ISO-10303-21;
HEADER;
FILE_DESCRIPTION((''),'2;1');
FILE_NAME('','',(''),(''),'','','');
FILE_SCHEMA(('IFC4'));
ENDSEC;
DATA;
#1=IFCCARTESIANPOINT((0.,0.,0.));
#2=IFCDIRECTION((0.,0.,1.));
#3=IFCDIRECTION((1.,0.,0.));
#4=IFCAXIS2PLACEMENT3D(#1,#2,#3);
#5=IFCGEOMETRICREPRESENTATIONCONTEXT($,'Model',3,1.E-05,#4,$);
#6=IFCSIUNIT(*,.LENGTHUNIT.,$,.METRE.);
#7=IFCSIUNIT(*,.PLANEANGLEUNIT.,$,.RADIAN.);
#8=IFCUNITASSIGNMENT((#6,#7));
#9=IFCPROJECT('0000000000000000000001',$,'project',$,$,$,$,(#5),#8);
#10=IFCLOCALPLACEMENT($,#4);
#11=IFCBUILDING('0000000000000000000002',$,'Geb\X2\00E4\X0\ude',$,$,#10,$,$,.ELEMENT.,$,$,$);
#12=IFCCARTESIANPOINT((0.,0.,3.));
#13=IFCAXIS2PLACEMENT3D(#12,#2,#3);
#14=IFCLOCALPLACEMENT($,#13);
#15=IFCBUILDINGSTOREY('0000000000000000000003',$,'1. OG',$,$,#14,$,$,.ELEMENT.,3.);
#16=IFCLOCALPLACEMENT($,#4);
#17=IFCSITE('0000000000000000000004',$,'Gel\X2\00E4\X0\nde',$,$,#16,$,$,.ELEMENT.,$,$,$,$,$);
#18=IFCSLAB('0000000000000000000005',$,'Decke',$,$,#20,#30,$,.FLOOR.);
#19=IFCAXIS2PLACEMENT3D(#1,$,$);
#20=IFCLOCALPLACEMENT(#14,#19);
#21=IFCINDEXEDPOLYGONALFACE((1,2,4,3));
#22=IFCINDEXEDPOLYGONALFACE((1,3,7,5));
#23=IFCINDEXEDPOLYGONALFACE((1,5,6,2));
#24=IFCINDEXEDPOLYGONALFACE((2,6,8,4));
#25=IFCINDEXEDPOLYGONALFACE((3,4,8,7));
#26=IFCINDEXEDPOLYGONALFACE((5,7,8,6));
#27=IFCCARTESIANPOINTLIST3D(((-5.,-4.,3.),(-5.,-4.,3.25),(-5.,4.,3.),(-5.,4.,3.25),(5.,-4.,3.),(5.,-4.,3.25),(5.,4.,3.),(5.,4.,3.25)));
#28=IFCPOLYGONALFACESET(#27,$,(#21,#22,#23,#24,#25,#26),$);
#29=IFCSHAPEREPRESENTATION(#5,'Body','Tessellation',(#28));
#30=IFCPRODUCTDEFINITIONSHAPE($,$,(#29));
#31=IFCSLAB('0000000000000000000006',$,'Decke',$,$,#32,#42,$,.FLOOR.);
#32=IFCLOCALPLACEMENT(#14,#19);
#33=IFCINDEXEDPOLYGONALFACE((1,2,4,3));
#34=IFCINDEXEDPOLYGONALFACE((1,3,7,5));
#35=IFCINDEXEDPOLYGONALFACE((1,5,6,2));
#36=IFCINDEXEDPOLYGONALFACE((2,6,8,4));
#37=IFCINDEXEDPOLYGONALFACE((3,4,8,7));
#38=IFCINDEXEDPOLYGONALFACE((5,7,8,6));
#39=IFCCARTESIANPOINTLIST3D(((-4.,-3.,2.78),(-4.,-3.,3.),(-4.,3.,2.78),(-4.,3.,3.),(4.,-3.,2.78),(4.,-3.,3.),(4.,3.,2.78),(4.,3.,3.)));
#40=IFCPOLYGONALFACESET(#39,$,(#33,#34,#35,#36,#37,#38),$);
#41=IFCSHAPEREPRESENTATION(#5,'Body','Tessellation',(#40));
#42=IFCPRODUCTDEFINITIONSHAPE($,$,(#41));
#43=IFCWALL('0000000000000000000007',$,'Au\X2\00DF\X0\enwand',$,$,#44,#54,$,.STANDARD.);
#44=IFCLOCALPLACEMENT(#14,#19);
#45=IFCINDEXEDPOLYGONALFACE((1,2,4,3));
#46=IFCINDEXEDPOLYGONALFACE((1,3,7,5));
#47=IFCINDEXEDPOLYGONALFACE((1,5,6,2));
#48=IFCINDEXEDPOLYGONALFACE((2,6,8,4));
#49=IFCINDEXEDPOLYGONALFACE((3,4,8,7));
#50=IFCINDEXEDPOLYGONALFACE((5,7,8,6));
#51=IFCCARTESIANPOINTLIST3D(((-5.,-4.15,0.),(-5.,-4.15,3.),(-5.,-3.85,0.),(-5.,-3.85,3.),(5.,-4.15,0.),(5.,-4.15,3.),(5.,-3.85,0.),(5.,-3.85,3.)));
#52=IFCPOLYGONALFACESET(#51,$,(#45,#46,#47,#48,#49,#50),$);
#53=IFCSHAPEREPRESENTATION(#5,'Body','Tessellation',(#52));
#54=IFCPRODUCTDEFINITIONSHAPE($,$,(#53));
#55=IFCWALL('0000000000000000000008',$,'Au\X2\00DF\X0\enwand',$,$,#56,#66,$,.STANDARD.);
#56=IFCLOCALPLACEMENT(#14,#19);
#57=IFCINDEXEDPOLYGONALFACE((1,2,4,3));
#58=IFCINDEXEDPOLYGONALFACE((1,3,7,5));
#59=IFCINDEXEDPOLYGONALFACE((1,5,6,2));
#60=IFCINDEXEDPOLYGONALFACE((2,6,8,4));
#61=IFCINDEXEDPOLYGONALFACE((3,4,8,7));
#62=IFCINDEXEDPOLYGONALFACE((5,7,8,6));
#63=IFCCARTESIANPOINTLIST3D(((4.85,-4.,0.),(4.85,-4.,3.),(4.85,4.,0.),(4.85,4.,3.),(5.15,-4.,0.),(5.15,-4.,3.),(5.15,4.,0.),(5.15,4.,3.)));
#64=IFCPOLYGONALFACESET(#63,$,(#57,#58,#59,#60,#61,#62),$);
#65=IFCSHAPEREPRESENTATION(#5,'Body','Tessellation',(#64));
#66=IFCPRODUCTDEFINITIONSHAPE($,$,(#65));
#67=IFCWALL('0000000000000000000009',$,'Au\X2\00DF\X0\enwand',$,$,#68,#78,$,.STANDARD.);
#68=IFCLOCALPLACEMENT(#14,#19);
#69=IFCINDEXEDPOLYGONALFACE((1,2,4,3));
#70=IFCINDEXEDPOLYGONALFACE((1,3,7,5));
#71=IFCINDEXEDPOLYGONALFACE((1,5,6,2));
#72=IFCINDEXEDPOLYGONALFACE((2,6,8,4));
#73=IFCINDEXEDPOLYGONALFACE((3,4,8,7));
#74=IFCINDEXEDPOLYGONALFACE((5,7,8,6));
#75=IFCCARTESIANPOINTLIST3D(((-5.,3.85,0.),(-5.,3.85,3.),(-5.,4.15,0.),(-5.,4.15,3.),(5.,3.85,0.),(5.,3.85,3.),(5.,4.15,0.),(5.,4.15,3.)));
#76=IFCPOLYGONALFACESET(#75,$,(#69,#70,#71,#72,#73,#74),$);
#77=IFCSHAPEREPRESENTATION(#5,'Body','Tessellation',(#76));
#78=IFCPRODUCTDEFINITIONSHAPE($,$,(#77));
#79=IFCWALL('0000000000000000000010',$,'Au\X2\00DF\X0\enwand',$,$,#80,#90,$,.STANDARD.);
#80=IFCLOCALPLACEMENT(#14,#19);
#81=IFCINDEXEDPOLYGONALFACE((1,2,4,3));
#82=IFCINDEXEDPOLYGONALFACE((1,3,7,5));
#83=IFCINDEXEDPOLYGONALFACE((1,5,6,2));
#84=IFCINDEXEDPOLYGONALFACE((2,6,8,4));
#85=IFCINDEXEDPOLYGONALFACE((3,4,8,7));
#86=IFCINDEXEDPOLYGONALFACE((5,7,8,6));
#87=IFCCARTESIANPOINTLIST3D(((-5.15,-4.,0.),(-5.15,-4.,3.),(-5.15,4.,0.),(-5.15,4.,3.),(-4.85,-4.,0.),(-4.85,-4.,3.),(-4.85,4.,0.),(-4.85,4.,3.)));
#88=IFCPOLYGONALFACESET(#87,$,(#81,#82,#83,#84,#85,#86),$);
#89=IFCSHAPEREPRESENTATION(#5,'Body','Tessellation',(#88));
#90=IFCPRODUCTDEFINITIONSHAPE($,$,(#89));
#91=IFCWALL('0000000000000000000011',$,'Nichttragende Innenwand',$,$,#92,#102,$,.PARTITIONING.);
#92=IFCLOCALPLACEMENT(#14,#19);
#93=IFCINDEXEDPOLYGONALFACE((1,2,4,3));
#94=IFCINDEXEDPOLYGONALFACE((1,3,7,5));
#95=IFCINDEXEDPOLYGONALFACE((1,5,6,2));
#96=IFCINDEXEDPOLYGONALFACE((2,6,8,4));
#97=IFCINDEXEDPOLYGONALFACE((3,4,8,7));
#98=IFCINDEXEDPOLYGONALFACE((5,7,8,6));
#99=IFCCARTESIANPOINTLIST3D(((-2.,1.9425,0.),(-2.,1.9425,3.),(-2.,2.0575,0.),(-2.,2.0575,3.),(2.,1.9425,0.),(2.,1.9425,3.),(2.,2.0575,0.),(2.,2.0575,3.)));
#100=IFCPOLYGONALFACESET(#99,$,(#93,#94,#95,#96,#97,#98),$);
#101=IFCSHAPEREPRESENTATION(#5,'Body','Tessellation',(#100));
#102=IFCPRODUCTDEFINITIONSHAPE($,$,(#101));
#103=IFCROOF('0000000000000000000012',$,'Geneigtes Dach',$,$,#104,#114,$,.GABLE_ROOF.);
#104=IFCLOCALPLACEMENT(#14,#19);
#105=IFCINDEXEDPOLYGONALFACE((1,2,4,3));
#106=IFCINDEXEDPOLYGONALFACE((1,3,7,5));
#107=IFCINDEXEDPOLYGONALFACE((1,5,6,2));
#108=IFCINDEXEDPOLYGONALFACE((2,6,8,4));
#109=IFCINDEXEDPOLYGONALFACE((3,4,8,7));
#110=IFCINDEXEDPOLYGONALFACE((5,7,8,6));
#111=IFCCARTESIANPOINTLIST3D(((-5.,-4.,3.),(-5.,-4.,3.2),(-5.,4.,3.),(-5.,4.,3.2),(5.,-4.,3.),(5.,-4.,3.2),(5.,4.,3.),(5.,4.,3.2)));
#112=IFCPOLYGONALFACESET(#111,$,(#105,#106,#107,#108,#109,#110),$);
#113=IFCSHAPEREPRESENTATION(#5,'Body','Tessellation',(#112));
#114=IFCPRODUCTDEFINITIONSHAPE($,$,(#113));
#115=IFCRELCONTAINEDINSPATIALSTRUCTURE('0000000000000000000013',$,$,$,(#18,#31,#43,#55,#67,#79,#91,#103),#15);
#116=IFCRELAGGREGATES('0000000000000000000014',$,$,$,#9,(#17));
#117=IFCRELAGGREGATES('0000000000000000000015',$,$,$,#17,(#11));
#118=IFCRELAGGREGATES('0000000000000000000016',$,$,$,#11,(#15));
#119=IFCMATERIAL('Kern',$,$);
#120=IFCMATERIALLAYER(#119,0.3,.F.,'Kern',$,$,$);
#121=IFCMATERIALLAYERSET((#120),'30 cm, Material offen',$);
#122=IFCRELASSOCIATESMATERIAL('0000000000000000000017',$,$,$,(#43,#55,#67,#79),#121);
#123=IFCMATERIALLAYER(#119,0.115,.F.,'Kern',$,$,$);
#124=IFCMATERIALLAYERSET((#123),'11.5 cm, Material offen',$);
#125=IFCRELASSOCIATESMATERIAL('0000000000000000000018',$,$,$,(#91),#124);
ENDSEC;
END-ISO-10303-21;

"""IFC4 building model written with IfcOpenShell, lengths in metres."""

from ifc_helpers import new_model, si_unit, frame, origin_with_axes, origin_2d, place, context, project, spatial, polyline, rectangle, outline, extrude, material, layer, layer_set, element, save


model = new_model("IFC4")

# Units and contexts
model_context = context("Model", 3, precision=1e-05, world=origin_with_axes())
ifc_project = project(units=[si_unit("LENGTHUNIT", "METRE"), si_unit("PLANEANGLEUNIT", "RADIAN")], contexts=[model_context])

# Site, building, storey
site_placement = place(None, origin_with_axes())
site = spatial("IfcSite", under=ifc_project, at=site_placement, Name="Gelände", CompositionType="ELEMENT")
building_placement = place(None, origin_with_axes())
building = spatial("IfcBuilding", under=site, at=building_placement, Name="Gebäude", CompositionType="ELEMENT")
storey_placement = place(None, frame((0.0, 0.0, 3.0), z_axis=(0.0, 0.0, 1.0), x_axis=(1.0, 0.0, 0.0)))
storey = spatial("IfcBuildingStorey", under=building, at=storey_placement, Name="1. OG", CompositionType="ELEMENT", Elevation=3.0)

# Slabs
slab_1_placement = place(None, frame((0.0, 0.0, 6.0), z_axis=(0.0, 0.0, 1.0), x_axis=(1.0, 0.0, 0.0)))
element("IfcSlab", 1, at=slab_1_placement, inside=storey, Name="Decke", PredefinedType="FLOOR", context=model_context, shape_type="SweptSolid", body=[
    extrude(outline(polyline([(-5.0, -4.0), (5.0, -4.0), (5.0, 4.0), (-5.0, 4.0), (-5.0, -4.0)])), origin_with_axes(), (0.0, 0.0, 1.0), 0.25),
])
slab_2_placement = place(None, frame((0.0, 0.0, 5.78), z_axis=(0.0, 0.0, 1.0), x_axis=(1.0, 0.0, 0.0)))
element("IfcSlab", 2, at=slab_2_placement, inside=storey, Name="Decke", PredefinedType="FLOOR", context=model_context, shape_type="SweptSolid", body=[
    extrude(outline(polyline([(-4.0, -3.0), (4.0, -3.0), (4.0, 3.0), (-4.0, 3.0), (-4.0, -3.0)])), origin_with_axes(), (0.0, 0.0, 1.0), 0.22),
])

# Walls
ifc_material = material(Name="Kern")
ifc_layer_1 = layer(ifc_material, 0.3, ventilated=False, Name="Kern")
ifc_layer_set_1 = layer_set([ifc_layer_1], Name="30 cm, Material offen")
wall_1_placement = place(None, frame((0.0, -4.0, 3.0), z_axis=(0.0, 0.0, 1.0), x_axis=(1.0, 0.0, 0.0)))
element("IfcWall", 3, at=wall_1_placement, inside=storey, material=ifc_layer_set_1, Name="Außenwand", PredefinedType="STANDARD", context=model_context, shape_type="SweptSolid", body=[
    extrude(rectangle(XDim=10.0, YDim=0.3, at=origin_2d()), origin_with_axes(), (0.0, 0.0, 1.0), 3.0),
])
wall_2_placement = place(None, frame((5.0, 0.0, 3.0), z_axis=(0.0, 0.0, 1.0), x_axis=(0.0, 1.0, 0.0)))
element("IfcWall", 4, at=wall_2_placement, inside=storey, material=ifc_layer_set_1, Name="Außenwand", PredefinedType="STANDARD", context=model_context, shape_type="SweptSolid", body=[
    extrude(rectangle(XDim=8.0, YDim=0.3, at=origin_2d()), origin_with_axes(), (0.0, 0.0, 1.0), 3.0),
])
wall_3_placement = place(None, frame((0.0, 4.0, 3.0), z_axis=(0.0, 0.0, 1.0), x_axis=(-1.0, 0.0, 0.0)))
element("IfcWall", 5, at=wall_3_placement, inside=storey, material=ifc_layer_set_1, Name="Außenwand", PredefinedType="STANDARD", context=model_context, shape_type="SweptSolid", body=[
    extrude(rectangle(XDim=10.0, YDim=0.3, at=origin_2d()), origin_with_axes(), (0.0, 0.0, 1.0), 3.0),
])
wall_4_placement = place(None, frame((-5.0, 0.0, 3.0), z_axis=(0.0, 0.0, 1.0), x_axis=(0.0, -1.0, 0.0)))
element("IfcWall", 6, at=wall_4_placement, inside=storey, material=ifc_layer_set_1, Name="Außenwand", PredefinedType="STANDARD", context=model_context, shape_type="SweptSolid", body=[
    extrude(rectangle(XDim=8.0, YDim=0.3, at=origin_2d()), origin_with_axes(), (0.0, 0.0, 1.0), 3.0),
])
ifc_layer_2 = layer(ifc_material, 0.115, ventilated=False, Name="Kern")
ifc_layer_set_2 = layer_set([ifc_layer_2], Name="11.5 cm, Material offen")
wall_5_placement = place(None, frame((0.0, 2.0, 3.0), z_axis=(0.0, 0.0, 1.0), x_axis=(1.0, 0.0, 0.0)))
element("IfcWall", 7, at=wall_5_placement, inside=storey, material=ifc_layer_set_2, Name="Nichttragende Innenwand", PredefinedType="PARTITIONING", context=model_context, shape_type="SweptSolid", body=[
    extrude(rectangle(XDim=4.0, YDim=0.115, at=origin_2d()), origin_with_axes(), (0.0, 0.0, 1.0), 3.0),
])

# Roof
roof_placement = place(None, frame((0.0, 0.0, 6.0), z_axis=(0.0, 0.0, 1.0), x_axis=(1.0, 0.0, 0.0)))
element("IfcRoof", 8, at=roof_placement, inside=storey, Name="Geneigtes Dach", PredefinedType="GABLE_ROOF", context=model_context, shape_type="SweptSolid", body=[
    extrude(outline(polyline([(-5.0, -4.0), (5.0, -4.0), (5.0, 4.0), (-5.0, 4.0), (-5.0, -4.0)])), origin_with_axes(), (0.0, 0.0, 1.0), 0.2),
])

save(model, "model.ifc")
